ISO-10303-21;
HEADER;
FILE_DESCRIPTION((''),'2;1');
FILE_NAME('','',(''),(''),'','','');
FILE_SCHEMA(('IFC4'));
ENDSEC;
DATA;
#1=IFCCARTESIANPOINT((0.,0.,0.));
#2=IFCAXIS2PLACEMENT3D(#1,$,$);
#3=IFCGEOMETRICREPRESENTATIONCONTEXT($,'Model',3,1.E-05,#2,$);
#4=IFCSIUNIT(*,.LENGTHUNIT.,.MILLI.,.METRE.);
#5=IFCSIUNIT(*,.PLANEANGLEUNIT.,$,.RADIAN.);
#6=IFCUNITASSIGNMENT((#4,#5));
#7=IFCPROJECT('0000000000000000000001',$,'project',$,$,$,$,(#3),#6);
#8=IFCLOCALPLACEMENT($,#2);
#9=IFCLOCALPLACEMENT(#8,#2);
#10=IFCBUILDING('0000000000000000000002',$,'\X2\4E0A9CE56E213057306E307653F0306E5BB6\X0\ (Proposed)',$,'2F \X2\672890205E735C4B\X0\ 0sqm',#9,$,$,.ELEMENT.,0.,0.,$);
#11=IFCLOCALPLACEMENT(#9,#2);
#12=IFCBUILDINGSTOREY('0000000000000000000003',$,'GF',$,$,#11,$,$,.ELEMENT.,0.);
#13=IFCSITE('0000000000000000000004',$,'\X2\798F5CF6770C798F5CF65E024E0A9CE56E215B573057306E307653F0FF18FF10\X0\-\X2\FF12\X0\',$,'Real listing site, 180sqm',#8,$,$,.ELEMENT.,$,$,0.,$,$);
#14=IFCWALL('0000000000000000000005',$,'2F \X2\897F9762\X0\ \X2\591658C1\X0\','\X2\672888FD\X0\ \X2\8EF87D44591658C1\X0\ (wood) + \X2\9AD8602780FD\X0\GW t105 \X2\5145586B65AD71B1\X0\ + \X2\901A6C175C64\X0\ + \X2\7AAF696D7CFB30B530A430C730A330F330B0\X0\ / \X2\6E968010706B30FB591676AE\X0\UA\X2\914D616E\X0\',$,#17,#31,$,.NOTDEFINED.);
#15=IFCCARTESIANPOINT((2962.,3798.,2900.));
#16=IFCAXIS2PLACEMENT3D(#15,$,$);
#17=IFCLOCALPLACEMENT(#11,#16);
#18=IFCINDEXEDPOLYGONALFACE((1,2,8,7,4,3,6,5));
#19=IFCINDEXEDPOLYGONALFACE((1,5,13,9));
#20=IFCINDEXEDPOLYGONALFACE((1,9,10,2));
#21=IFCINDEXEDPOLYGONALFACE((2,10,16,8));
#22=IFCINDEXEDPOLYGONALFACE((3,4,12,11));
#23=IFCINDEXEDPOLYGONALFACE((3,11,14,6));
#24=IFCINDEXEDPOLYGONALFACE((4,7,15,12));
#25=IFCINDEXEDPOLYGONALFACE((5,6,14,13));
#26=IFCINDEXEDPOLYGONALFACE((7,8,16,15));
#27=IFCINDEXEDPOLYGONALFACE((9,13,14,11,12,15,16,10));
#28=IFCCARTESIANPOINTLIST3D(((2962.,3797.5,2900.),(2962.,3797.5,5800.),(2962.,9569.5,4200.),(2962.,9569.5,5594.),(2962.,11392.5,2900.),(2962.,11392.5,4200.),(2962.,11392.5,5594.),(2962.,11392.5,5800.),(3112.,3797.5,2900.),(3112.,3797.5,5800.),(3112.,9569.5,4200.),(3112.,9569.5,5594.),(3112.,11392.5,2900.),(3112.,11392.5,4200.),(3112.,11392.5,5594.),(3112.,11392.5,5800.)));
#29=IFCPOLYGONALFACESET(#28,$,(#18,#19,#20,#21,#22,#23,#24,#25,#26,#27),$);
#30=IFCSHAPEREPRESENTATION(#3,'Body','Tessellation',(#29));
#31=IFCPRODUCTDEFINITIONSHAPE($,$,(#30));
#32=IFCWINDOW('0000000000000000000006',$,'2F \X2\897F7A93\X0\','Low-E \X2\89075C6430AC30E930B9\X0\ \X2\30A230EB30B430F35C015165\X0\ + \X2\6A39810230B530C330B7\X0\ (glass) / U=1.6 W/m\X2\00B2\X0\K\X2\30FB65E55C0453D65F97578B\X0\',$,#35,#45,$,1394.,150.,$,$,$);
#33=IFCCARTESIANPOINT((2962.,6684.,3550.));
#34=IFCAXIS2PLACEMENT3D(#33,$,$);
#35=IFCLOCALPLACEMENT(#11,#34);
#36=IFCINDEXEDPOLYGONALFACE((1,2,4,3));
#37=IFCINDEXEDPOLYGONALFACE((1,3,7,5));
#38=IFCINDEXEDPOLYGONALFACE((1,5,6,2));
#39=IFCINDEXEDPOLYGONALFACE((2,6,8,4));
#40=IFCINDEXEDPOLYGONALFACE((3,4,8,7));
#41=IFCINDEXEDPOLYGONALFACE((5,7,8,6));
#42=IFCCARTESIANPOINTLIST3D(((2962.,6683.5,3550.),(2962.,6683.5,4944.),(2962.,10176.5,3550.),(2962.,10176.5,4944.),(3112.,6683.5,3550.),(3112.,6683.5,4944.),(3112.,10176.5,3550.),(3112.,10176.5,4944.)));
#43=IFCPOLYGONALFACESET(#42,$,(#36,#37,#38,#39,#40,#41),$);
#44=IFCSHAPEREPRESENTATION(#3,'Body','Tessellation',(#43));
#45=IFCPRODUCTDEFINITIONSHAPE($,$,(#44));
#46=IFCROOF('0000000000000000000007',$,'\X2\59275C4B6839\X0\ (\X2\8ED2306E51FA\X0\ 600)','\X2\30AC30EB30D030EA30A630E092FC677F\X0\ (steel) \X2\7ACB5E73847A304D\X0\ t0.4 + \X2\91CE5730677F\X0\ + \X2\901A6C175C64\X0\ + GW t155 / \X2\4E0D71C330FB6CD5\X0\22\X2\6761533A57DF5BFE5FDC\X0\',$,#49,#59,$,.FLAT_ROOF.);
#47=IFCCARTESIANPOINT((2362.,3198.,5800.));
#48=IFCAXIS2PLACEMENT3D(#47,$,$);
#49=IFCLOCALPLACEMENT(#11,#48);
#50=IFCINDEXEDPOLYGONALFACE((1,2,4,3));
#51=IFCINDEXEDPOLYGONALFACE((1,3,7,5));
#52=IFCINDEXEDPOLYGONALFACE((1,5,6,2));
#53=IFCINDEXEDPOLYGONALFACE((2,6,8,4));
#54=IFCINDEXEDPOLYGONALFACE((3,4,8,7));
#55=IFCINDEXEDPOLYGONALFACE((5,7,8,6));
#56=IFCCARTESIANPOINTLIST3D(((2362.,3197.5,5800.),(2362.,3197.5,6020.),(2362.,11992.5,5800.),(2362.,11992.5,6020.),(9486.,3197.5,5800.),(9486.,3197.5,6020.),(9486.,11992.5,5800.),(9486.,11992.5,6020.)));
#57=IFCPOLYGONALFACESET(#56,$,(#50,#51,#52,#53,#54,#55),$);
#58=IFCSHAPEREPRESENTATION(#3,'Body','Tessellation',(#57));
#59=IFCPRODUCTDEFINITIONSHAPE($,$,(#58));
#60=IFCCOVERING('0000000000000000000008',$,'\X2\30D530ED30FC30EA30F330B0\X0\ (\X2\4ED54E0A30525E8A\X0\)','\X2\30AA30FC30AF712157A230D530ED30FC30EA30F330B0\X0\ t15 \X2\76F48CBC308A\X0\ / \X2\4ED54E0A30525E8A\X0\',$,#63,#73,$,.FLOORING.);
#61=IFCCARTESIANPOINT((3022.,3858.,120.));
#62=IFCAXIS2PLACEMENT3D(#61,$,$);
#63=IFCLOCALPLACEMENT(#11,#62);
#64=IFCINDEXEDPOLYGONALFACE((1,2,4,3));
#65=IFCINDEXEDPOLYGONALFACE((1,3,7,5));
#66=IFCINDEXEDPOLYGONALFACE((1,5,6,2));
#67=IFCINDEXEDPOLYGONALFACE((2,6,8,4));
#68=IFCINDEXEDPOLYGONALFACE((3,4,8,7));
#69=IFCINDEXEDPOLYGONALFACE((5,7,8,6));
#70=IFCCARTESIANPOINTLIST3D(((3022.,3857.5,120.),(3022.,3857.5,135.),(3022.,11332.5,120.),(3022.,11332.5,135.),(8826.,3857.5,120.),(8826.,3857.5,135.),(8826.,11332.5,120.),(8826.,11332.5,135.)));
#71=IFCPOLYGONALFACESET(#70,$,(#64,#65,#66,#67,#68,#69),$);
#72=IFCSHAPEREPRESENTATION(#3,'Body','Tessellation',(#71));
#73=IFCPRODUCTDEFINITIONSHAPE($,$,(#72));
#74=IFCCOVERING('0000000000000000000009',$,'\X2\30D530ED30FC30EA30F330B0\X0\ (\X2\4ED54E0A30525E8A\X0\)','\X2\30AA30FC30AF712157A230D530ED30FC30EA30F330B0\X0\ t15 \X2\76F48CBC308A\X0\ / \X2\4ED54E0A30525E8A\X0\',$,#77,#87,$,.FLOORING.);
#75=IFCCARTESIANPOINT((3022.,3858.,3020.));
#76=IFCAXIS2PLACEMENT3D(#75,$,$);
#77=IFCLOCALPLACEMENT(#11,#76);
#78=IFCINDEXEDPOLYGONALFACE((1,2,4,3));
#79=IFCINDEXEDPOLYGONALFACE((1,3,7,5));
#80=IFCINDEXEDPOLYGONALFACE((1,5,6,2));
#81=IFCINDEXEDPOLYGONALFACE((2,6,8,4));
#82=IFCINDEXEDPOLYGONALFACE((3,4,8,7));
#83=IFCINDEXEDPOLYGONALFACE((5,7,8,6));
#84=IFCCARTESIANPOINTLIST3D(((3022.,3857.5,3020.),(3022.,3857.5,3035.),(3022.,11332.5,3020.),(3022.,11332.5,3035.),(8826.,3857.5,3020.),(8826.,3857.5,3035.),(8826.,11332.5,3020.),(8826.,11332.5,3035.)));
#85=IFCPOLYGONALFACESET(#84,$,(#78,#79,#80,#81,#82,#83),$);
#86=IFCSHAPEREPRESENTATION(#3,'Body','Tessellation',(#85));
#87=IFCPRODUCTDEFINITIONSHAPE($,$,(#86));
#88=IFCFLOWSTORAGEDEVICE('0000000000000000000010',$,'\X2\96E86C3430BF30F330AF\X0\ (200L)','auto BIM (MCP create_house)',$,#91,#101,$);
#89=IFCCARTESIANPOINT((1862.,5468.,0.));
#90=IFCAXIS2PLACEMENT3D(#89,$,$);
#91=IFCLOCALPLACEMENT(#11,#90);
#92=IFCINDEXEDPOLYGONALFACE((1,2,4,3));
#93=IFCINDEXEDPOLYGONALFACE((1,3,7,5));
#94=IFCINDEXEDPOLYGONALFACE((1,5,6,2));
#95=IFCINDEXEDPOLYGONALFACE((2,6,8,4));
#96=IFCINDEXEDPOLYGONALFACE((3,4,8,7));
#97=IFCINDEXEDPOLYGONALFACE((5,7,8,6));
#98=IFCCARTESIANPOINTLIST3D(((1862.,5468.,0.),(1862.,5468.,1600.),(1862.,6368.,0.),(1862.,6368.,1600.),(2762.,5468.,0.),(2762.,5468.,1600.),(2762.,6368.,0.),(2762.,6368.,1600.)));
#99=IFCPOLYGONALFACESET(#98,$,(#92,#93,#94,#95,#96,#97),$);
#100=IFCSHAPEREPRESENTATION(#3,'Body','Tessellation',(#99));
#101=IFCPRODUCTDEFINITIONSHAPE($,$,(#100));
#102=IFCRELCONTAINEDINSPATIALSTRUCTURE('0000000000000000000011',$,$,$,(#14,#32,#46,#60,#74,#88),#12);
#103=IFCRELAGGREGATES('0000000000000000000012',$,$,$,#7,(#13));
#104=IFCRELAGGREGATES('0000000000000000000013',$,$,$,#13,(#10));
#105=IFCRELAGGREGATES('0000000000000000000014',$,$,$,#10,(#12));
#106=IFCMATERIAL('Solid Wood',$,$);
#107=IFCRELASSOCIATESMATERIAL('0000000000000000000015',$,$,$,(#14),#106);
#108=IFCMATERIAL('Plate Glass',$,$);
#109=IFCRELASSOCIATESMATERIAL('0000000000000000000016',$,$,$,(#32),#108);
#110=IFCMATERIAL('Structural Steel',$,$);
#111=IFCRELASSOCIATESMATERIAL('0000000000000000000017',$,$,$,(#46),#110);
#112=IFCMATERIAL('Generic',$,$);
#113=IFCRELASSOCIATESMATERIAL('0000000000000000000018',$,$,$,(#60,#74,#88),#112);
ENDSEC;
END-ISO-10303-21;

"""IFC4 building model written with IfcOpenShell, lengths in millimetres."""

from ifc_helpers import new_model, si_unit, frame, frame_2d, origin, place, context, project, spatial, rectangle, extrude, material, element, fill, save


model = new_model("IFC4")

# Units and contexts
model_context = context("Model", 3, precision=1e-05, world=origin())
ifc_project = project(units=[si_unit("LENGTHUNIT", "METRE", prefix="MILLI"), si_unit("PLANEANGLEUNIT", "RADIAN")], contexts=[model_context])

# Site, building, storey
site_placement = place(None, origin())
site = spatial("IfcSite", under=ifc_project, at=site_placement, Name="福島県福島市上鳥渡字しのぶ台８０-２", ObjectType="Real listing site, 180sqm", CompositionType="ELEMENT", RefElevation=0.0)
building_placement = place(site_placement, origin())
building = spatial("IfcBuilding", under=site, at=building_placement, Name="上鳥渡しのぶ台の家 (Proposed)", ObjectType="2F 木造平屋 0sqm", CompositionType="ELEMENT", ElevationOfRefHeight=0.0, ElevationOfTerrain=0.0)
storey_placement = place(building_placement, origin())
storey = spatial("IfcBuildingStorey", under=building, at=storey_placement, Name="GF", CompositionType="ELEMENT", Elevation=0.0)

# Shared definitions
ifc_material_1 = material(Name="Solid Wood")

# Shared definitions
ifc_material_2 = material(Name="Plate Glass")

# Wall, opening, window
wall_1_placement = place(storey_placement, frame((2962.0, 3798.0, 2900.0)))
wall_1 = element("IfcWall", 1, at=wall_1_placement, inside=storey, material=ifc_material_1, Name="2F 西面 外壁", Description="木製 軸組外壁 (wood) + 高性能GW t105 充填断熱 + 通気層 + 窯業系サイディング / 準耐火・外皮UA配慮", PredefinedType="NOTDEFINED", context=model_context, shape_type="SweptSolid", body=[
    extrude(rectangle(XDim=150.0, YDim=7595.0, at=frame_2d((75.0, 3797.0))), frame((2962.0, 3798.0, 2900.0)), (0.0, 0.0, 1.0), 2900.0),
])
opening_1_placement = place(storey_placement, frame((2962.0, 6684.0, 3550.0)))
opening_1 = element("IfcOpeningElement", 2, at=opening_1_placement, cuts=wall_1, PredefinedType="NOTDEFINED", context=model_context, shape_type="SweptSolid", body=[
    extrude(rectangle(XDim=150.0, YDim=3493.0, at=frame_2d((75.0, 1746.0))), frame((2962.0, 6684.0, 3550.0)), (0.0, 0.0, 1.0), 1394.0),
])
window_1_placement = place(storey_placement, frame((2962.0, 6684.0, 3550.0)))
window_1 = element("IfcWindow", 3, at=window_1_placement, inside=storey, material=ifc_material_2, Name="2F 西窓", Description="Low-E 複層ガラス アルゴン封入 + 樹脂サッシ (glass) / U=1.6 W/m²K・日射取得型", OverallHeight=1394.0, OverallWidth=150.0, context=model_context, shape_type="SweptSolid", body=[
    extrude(rectangle(XDim=150.0, YDim=3493.0, at=frame_2d((75.0, 1746.0))), frame((2962.0, 6684.0, 3550.0)), (0.0, 0.0, 1.0), 1394.0),
])
fill(opening_1, window_1)

# Roof
ifc_material_3 = material(Name="Structural Steel")
roof_placement = place(storey_placement, frame((2362.0, 3198.0, 5800.0)))
element("IfcRoof", 4, at=roof_placement, inside=storey, material=ifc_material_3, Name="大屋根 (軒の出 600)", Description="ガルバリウム鋼板 (steel) 立平葺き t0.4 + 野地板 + 通気層 + GW t155 / 不燃・法22条区域対応", PredefinedType="FLAT_ROOF", context=model_context, shape_type="SweptSolid", body=[
    extrude(rectangle(XDim=7124.0, YDim=8795.0, at=frame_2d((3562.0, 4397.0))), frame((2362.0, 3198.0, 5800.0)), (0.0, 0.0, 1.0), 220.0),
])

# Coverings
ifc_material_4 = material(Name="Generic")
covering_1_placement = place(storey_placement, frame((3022.0, 3858.0, 120.0)))
element("IfcCovering", 5, at=covering_1_placement, inside=storey, material=ifc_material_4, Name="フローリング (仕上げ床)", Description="オーク無垢フローリング t15 直貼り / 仕上げ床", PredefinedType="FLOORING", context=model_context, shape_type="SweptSolid", body=[
    extrude(rectangle(XDim=5804.0, YDim=7475.0, at=frame_2d((2902.0, 3737.0))), frame((3022.0, 3858.0, 120.0)), (0.0, 0.0, 1.0), 15.0),
])
covering_2_placement = place(storey_placement, frame((3022.0, 3858.0, 3020.0)))
element("IfcCovering", 6, at=covering_2_placement, inside=storey, material=ifc_material_4, Name="フローリング (仕上げ床)", Description="オーク無垢フローリング t15 直貼り / 仕上げ床", PredefinedType="FLOORING", context=model_context, shape_type="SweptSolid", body=[
    extrude(rectangle(XDim=5804.0, YDim=7475.0, at=frame_2d((2902.0, 3737.0))), frame((3022.0, 3858.0, 3020.0)), (0.0, 0.0, 1.0), 15.0),
])

# Flow storage device
flow_storage_device_placement = place(storey_placement, frame((1862.0, 5468.0, 0.0)))
element("IfcFlowStorageDevice", 7, at=flow_storage_device_placement, inside=storey, material=ifc_material_4, Name="雨水タンク (200L)", Description="auto BIM (MCP create_house)", context=model_context, shape_type="SweptSolid", body=[
    extrude(rectangle(XDim=900.0, YDim=900.0, at=frame_2d((450.0, 450.0))), frame((1862.0, 5468.0, 0.0)), (0.0, 0.0, 1.0), 1600.0),
])

save(model, "model.ifc")
